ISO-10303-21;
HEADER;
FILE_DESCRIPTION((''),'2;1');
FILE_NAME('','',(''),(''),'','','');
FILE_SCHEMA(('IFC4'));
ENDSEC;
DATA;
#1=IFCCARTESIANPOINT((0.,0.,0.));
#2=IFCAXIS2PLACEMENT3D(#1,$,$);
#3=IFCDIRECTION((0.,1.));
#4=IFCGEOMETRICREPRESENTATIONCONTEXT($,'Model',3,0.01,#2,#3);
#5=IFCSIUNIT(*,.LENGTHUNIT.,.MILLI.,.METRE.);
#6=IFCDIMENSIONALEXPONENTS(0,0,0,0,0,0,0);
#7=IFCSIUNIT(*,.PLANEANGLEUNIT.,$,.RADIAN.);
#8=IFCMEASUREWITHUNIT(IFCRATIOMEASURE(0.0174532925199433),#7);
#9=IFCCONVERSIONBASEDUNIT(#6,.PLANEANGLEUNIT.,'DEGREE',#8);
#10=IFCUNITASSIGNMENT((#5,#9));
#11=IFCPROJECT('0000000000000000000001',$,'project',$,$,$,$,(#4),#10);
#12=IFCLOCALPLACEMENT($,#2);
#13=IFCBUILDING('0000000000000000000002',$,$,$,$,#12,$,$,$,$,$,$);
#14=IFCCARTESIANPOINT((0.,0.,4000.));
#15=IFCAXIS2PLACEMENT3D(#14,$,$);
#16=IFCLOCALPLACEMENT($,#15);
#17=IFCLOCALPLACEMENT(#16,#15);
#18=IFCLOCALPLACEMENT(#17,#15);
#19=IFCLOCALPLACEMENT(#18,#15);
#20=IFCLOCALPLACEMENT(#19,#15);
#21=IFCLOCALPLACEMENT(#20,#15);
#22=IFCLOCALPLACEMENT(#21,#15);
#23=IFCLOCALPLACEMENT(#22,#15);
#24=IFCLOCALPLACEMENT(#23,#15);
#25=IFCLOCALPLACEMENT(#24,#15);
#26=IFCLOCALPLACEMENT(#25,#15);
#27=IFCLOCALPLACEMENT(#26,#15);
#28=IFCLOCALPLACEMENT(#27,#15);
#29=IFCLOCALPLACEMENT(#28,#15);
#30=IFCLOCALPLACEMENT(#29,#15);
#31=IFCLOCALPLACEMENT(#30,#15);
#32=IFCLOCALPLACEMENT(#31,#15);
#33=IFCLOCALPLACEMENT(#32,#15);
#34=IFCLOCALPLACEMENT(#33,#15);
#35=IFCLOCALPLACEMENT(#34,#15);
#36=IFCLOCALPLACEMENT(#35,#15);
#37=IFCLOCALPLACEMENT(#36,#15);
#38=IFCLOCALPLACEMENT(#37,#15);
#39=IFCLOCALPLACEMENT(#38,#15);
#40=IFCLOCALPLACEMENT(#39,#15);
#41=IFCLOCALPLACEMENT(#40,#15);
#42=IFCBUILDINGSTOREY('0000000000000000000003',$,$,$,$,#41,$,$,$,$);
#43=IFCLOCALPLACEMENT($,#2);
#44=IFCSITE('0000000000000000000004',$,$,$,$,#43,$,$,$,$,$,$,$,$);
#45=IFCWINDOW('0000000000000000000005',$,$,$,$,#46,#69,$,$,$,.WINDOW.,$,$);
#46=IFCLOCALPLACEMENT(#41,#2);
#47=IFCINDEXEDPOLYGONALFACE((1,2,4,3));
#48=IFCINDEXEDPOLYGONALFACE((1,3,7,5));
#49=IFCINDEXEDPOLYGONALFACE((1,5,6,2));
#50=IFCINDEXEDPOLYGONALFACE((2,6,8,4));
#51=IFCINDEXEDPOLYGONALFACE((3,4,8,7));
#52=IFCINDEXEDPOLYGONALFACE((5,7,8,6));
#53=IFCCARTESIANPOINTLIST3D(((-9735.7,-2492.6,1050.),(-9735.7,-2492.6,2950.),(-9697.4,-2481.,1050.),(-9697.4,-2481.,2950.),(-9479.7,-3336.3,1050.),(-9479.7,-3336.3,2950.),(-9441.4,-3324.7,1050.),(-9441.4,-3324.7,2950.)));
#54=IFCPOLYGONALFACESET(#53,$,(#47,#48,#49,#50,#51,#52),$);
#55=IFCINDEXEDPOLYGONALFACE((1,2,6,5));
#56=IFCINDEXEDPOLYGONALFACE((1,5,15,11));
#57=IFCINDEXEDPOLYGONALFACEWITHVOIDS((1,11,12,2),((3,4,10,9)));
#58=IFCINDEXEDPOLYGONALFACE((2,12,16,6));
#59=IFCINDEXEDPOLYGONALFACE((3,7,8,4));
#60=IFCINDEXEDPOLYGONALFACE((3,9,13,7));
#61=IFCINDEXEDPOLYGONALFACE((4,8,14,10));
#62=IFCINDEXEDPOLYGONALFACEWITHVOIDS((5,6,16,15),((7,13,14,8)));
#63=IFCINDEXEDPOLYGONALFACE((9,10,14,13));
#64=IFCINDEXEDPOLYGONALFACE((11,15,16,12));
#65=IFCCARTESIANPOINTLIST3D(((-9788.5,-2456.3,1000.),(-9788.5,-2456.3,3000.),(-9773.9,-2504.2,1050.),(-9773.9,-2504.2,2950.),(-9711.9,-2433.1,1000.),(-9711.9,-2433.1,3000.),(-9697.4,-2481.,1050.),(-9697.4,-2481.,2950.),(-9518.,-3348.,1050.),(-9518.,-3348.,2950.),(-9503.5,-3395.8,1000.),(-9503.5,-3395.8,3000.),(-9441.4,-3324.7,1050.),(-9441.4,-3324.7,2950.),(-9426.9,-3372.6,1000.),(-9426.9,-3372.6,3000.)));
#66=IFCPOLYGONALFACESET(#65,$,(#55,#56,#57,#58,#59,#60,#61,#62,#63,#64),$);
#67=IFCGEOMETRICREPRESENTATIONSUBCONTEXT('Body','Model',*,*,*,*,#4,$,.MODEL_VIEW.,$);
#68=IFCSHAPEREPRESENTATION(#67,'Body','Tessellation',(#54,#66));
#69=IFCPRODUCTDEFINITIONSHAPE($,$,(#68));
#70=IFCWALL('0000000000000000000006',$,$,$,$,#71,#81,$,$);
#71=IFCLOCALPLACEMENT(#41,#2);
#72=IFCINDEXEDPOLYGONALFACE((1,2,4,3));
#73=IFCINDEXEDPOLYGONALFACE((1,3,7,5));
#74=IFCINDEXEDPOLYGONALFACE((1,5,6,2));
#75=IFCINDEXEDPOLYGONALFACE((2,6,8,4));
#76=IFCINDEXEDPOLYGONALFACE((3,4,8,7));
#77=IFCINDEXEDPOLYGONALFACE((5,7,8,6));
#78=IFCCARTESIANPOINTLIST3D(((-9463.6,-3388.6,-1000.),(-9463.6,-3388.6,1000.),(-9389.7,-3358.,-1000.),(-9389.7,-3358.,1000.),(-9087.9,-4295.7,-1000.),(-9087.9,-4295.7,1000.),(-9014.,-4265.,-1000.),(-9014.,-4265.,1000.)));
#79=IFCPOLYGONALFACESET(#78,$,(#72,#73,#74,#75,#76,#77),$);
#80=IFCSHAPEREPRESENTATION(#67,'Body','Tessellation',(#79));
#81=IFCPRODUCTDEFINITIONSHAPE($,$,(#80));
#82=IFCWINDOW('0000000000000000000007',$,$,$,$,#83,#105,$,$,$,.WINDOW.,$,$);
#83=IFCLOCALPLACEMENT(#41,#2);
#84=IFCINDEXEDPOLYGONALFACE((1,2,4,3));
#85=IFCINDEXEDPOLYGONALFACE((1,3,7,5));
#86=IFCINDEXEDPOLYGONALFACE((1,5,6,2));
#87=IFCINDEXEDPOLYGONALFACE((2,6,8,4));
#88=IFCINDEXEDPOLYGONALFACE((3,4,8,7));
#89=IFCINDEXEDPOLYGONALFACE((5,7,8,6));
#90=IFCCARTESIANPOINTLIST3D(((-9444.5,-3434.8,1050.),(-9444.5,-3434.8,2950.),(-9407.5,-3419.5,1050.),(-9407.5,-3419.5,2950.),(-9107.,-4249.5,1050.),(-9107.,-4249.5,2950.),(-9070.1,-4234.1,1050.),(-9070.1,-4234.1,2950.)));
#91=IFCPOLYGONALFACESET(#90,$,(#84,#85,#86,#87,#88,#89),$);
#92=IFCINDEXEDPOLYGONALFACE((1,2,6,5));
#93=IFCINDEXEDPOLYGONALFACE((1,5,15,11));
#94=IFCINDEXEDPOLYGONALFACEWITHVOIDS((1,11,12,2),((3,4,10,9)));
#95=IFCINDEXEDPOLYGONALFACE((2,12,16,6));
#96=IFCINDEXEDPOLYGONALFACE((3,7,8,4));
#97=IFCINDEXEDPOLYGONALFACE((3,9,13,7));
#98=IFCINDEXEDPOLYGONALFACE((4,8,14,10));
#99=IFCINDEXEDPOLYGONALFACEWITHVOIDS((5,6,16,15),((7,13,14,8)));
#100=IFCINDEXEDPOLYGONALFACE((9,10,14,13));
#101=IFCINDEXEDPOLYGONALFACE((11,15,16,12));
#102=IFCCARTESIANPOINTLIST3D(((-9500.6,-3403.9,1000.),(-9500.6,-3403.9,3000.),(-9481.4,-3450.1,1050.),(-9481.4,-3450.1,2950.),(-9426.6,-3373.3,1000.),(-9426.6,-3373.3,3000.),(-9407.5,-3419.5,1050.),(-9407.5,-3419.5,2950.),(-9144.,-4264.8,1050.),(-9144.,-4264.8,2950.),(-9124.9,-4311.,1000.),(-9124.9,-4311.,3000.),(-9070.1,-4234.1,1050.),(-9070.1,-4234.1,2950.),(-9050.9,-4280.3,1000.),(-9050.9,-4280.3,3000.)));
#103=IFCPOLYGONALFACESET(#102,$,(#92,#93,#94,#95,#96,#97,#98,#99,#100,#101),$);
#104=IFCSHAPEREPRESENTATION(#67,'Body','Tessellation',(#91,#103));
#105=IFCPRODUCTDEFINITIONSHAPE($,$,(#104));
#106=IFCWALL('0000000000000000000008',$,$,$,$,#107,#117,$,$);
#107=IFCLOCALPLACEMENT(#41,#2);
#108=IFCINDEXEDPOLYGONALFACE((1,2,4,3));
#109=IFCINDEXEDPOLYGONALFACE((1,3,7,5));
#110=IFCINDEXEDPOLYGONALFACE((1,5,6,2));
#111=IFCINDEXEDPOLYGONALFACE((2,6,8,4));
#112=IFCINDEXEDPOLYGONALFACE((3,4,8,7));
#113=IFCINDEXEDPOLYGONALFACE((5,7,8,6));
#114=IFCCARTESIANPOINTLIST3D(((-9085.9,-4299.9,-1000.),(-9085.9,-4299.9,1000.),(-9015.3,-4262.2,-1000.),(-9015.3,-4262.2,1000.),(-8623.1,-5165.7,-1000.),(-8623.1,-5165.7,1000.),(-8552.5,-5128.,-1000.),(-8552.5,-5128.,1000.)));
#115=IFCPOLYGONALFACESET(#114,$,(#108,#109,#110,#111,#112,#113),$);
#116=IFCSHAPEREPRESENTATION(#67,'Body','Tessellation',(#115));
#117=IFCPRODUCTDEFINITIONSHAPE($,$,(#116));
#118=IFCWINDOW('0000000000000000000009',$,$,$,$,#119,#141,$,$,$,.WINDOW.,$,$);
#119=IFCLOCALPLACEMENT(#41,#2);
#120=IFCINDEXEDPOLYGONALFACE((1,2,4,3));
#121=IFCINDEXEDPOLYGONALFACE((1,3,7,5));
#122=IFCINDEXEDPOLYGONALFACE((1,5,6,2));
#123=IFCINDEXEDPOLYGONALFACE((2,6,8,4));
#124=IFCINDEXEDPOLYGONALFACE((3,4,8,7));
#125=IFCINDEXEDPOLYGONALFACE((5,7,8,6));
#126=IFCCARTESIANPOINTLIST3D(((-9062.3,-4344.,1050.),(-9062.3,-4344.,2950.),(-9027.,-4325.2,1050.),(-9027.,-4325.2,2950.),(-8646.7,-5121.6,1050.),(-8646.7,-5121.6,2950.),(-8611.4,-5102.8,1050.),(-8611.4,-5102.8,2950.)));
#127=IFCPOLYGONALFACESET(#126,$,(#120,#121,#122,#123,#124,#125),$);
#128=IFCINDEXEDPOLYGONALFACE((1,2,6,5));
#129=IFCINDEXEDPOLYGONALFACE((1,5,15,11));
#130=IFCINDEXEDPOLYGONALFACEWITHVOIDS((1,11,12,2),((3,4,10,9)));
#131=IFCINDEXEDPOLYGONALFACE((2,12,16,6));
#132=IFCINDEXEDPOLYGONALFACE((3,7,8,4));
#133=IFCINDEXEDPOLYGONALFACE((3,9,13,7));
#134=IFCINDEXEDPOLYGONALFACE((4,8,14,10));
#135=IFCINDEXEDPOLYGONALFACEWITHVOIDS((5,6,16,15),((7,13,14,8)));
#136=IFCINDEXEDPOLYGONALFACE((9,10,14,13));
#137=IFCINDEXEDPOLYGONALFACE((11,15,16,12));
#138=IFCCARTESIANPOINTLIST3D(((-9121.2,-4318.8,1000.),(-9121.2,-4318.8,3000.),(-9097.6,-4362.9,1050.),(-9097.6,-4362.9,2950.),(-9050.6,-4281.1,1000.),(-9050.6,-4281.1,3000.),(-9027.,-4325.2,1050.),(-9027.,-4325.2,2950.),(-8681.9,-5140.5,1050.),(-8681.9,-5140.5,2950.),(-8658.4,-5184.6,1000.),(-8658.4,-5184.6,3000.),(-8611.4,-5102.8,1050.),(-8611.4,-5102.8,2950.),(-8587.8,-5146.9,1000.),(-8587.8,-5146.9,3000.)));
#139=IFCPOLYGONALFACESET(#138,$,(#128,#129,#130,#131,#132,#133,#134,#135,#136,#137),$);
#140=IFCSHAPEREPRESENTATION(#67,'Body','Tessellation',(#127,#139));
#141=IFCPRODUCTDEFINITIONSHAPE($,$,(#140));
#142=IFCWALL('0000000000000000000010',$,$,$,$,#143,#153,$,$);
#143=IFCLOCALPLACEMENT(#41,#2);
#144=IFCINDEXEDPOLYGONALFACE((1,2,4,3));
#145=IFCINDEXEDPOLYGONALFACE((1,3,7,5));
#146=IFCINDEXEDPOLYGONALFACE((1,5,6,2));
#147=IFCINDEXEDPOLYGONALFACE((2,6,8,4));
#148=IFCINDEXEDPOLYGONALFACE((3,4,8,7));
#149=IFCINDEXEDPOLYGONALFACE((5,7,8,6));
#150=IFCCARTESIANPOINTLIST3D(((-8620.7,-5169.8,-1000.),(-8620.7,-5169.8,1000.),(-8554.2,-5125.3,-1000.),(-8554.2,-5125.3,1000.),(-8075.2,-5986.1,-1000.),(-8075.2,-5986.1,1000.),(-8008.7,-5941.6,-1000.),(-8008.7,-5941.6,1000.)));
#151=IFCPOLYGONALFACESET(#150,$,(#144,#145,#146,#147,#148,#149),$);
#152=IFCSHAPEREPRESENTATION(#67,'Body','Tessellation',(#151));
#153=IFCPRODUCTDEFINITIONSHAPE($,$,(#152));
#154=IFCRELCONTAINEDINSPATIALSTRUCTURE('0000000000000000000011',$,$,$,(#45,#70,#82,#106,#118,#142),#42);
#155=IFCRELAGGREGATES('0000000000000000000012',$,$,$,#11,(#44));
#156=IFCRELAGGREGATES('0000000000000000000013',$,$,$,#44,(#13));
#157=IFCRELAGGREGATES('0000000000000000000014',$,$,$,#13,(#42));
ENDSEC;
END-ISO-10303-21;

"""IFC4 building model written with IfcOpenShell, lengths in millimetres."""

from ifc_helpers import new_model, entity, si_unit, converted_unit, direction, frame, origin, origin_2d, place, context, subcontext, project, spatial, rectangle, extrude, element, save


model = new_model("IFC4")

# Units and contexts
model_context = context("Model", 3, precision=0.01, world=origin(), true_north=direction((0.0, 1.0)))
body_context = subcontext(model_context, "Body", "Model", "MODEL_VIEW")
ifc_project = project(units=[si_unit("LENGTHUNIT", "METRE", prefix="MILLI"), converted_unit("PLANEANGLEUNIT", "DEGREE", entity("IfcRatioMeasure", 0.0174532925199433), si_unit("PLANEANGLEUNIT", "RADIAN"), dimensions=[0, 0, 0, 0, 0, 0, 0])], contexts=[model_context])

# Site, building, storey
site_placement = place(None, origin())
site = spatial("IfcSite", under=ifc_project, at=site_placement)
building_placement = place(None, origin())
building = spatial("IfcBuilding", under=site, at=building_placement)
placement_1 = place(None, frame((0.0, 0.0, 4000.0)))
placement_2 = place(placement_1, frame((0.0, 0.0, 4000.0)))
placement_3 = place(placement_2, frame((0.0, 0.0, 4000.0)))
placement_4 = place(placement_3, frame((0.0, 0.0, 4000.0)))
placement_5 = place(placement_4, frame((0.0, 0.0, 4000.0)))
placement_6 = place(placement_5, frame((0.0, 0.0, 4000.0)))
placement_7 = place(placement_6, frame((0.0, 0.0, 4000.0)))
placement_8 = place(placement_7, frame((0.0, 0.0, 4000.0)))
placement_9 = place(placement_8, frame((0.0, 0.0, 4000.0)))
placement_10 = place(placement_9, frame((0.0, 0.0, 4000.0)))
placement_11 = place(placement_10, frame((0.0, 0.0, 4000.0)))
placement_12 = place(placement_11, frame((0.0, 0.0, 4000.0)))
placement_13 = place(placement_12, frame((0.0, 0.0, 4000.0)))
placement_14 = place(placement_13, frame((0.0, 0.0, 4000.0)))
placement_15 = place(placement_14, frame((0.0, 0.0, 4000.0)))
placement_16 = place(placement_15, frame((0.0, 0.0, 4000.0)))
placement_17 = place(placement_16, frame((0.0, 0.0, 4000.0)))
placement_18 = place(placement_17, frame((0.0, 0.0, 4000.0)))
placement_19 = place(placement_18, frame((0.0, 0.0, 4000.0)))
placement_20 = place(placement_19, frame((0.0, 0.0, 4000.0)))
placement_21 = place(placement_20, frame((0.0, 0.0, 4000.0)))
placement_22 = place(placement_21, frame((0.0, 0.0, 4000.0)))
placement_23 = place(placement_22, frame((0.0, 0.0, 4000.0)))
placement_24 = place(placement_23, frame((0.0, 0.0, 4000.0)))
placement_25 = place(placement_24, frame((0.0, 0.0, 4000.0)))
storey_placement = place(placement_25, frame((0.0, 0.0, 4000.0)))
storey = spatial("IfcBuildingStorey", under=building, at=storey_placement)

# Shared definitions
cartesian_point_1 = entity("IfcCartesianPoint", [-440.9, -950.0])
shared_polyline = entity("IfcPolyline", [cartesian_point_1, entity("IfcCartesianPoint", [-440.9, 950.0]), entity("IfcCartesianPoint", [-440.9, 950.0]), entity("IfcCartesianPoint", [440.9, 950.0]), entity("IfcCartesianPoint", [440.9, 950.0]), entity("IfcCartesianPoint", [440.9, -950.0]), entity("IfcCartesianPoint", [440.9, -950.0]), entity("IfcCartesianPoint", [-440.9, -950.0]), cartesian_point_1])

# Window
window_1_placement = place(storey_placement, frame((-9569.4, -2902.8, 2000.0), z_axis=(0.0, 0.0, 1.0), x_axis=(2902.846475, -9569.403447, 0.0)))
cartesian_point_2 = entity("IfcCartesianPoint", [-490.9, -1000.0])
element("IfcWindow", 1, at=window_1_placement, inside=storey, PredefinedType="WINDOW", context=body_context, shape_type="SweptSolid", body=[
    entity("IfcExtrudedAreaSolid", entity("IfcArbitraryClosedProfileDef", "AREA", None, shared_polyline), entity("IfcAxis2Placement3D", entity("IfcCartesianPoint", [0.0, 0.0, 0.0]), entity("IfcDirection", [0.0, -1.0, 0.0]), entity("IfcDirection", [1.0, 0.0, 0.0])), entity("IfcDirection", [0.0, 0.0, 1.0]), 40.0),
    entity("IfcExtrudedAreaSolid", entity("IfcArbitraryProfileDefWithVoids", "AREA", None, entity("IfcPolyline", [cartesian_point_2, entity("IfcCartesianPoint", [-490.9, 1000.0]), entity("IfcCartesianPoint", [-490.9, 1000.0]), entity("IfcCartesianPoint", [490.9, 1000.0]), entity("IfcCartesianPoint", [490.9, 1000.0]), entity("IfcCartesianPoint", [490.9, -1000.0]), entity("IfcCartesianPoint", [490.9, -1000.0]), entity("IfcCartesianPoint", [-490.9, -1000.0]), cartesian_point_2]), [shared_polyline]), entity("IfcAxis2Placement3D", entity("IfcCartesianPoint", [0.0, 0.0, 0.0]), entity("IfcDirection", [0.0, -1.0, 0.0]), entity("IfcDirection", [1.0, 0.0, 0.0])), entity("IfcDirection", [0.0, 0.0, 1.0]), 80.0),
])

# Wall
wall_1_placement = place(storey_placement, frame((-9238.8, -3826.8, -1000.0), z_axis=(0.0, 0.0, 1.0), x_axis=(3826.834406, -9238.795291, 0.0)))
element("IfcWall", 2, at=wall_1_placement, inside=storey, context=body_context, shape_type="SweptSolid", body=[
    extrude(rectangle(XDim=981.7, YDim=80.0, at=origin_2d()), origin(), (0.0, 0.0, 1.0), 2000.0),
])

# Window
window_2_placement = place(storey_placement, frame((-9238.8, -3826.8, 2000.0), z_axis=(0.0, 0.0, 1.0), x_axis=(3826.834406, -9238.795291, 0.0)))
cartesian_point_3 = entity("IfcCartesianPoint", [-490.9, -1000.0])
element("IfcWindow", 3, at=window_2_placement, inside=storey, PredefinedType="WINDOW", context=body_context, shape_type="SweptSolid", body=[
    entity("IfcExtrudedAreaSolid", entity("IfcArbitraryClosedProfileDef", "AREA", None, shared_polyline), entity("IfcAxis2Placement3D", entity("IfcCartesianPoint", [0.0, 0.0, 0.0]), entity("IfcDirection", [0.0, -1.0, 0.0]), entity("IfcDirection", [1.0, 0.0, 0.0])), entity("IfcDirection", [0.0, 0.0, 1.0]), 40.0),
    entity("IfcExtrudedAreaSolid", entity("IfcArbitraryProfileDefWithVoids", "AREA", None, entity("IfcPolyline", [cartesian_point_3, entity("IfcCartesianPoint", [-490.9, 1000.0]), entity("IfcCartesianPoint", [-490.9, 1000.0]), entity("IfcCartesianPoint", [490.9, 1000.0]), entity("IfcCartesianPoint", [490.9, 1000.0]), entity("IfcCartesianPoint", [490.9, -1000.0]), entity("IfcCartesianPoint", [490.9, -1000.0]), entity("IfcCartesianPoint", [-490.9, -1000.0]), cartesian_point_3]), [shared_polyline]), entity("IfcAxis2Placement3D", entity("IfcCartesianPoint", [0.0, 0.0, 0.0]), entity("IfcDirection", [0.0, -1.0, 0.0]), entity("IfcDirection", [1.0, 0.0, 0.0])), entity("IfcDirection", [0.0, 0.0, 1.0]), 80.0),
])

# Wall
wall_2_placement = place(storey_placement, frame((-8819.2, -4714.0, -1000.0), z_axis=(0.0, 0.0, 1.0), x_axis=(4713.9678, -8819.212413, 0.0)))
element("IfcWall", 4, at=wall_2_placement, inside=storey, context=body_context, shape_type="SweptSolid", body=[
    extrude(rectangle(XDim=981.7, YDim=80.0, at=origin_2d()), origin(), (0.0, 0.0, 1.0), 2000.0),
])

# Window
window_3_placement = place(storey_placement, frame((-8819.2, -4714.0, 2000.0), z_axis=(0.0, 0.0, 1.0), x_axis=(4713.9678, -8819.212413, 0.0)))
cartesian_point_4 = entity("IfcCartesianPoint", [-490.9, -1000.0])
element("IfcWindow", 5, at=window_3_placement, inside=storey, PredefinedType="WINDOW", context=body_context, shape_type="SweptSolid", body=[
    entity("IfcExtrudedAreaSolid", entity("IfcArbitraryClosedProfileDef", "AREA", None, shared_polyline), entity("IfcAxis2Placement3D", entity("IfcCartesianPoint", [0.0, 0.0, 0.0]), entity("IfcDirection", [0.0, -1.0, 0.0]), entity("IfcDirection", [1.0, 0.0, 0.0])), entity("IfcDirection", [0.0, 0.0, 1.0]), 40.0),
    entity("IfcExtrudedAreaSolid", entity("IfcArbitraryProfileDefWithVoids", "AREA", None, entity("IfcPolyline", [cartesian_point_4, entity("IfcCartesianPoint", [-490.9, 1000.0]), entity("IfcCartesianPoint", [-490.9, 1000.0]), entity("IfcCartesianPoint", [490.9, 1000.0]), entity("IfcCartesianPoint", [490.9, 1000.0]), entity("IfcCartesianPoint", [490.9, -1000.0]), entity("IfcCartesianPoint", [490.9, -1000.0]), entity("IfcCartesianPoint", [-490.9, -1000.0]), cartesian_point_4]), [shared_polyline]), entity("IfcAxis2Placement3D", entity("IfcCartesianPoint", [0.0, 0.0, 0.0]), entity("IfcDirection", [0.0, -1.0, 0.0]), entity("IfcDirection", [1.0, 0.0, 0.0])), entity("IfcDirection", [0.0, 0.0, 1.0]), 80.0),
])

# Wall
wall_3_placement = place(storey_placement, frame((-8314.7, -5555.7, -1000.0), z_axis=(0.0, 0.0, 1.0), x_axis=(5555.703069, -8314.695629, 0.0)))
element("IfcWall", 6, at=wall_3_placement, inside=storey, context=body_context, shape_type="SweptSolid", body=[
    extrude(rectangle(XDim=981.7, YDim=80.0, at=origin_2d()), origin(), (0.0, 0.0, 1.0), 2000.0),
])

save(model, "model.ifc")
